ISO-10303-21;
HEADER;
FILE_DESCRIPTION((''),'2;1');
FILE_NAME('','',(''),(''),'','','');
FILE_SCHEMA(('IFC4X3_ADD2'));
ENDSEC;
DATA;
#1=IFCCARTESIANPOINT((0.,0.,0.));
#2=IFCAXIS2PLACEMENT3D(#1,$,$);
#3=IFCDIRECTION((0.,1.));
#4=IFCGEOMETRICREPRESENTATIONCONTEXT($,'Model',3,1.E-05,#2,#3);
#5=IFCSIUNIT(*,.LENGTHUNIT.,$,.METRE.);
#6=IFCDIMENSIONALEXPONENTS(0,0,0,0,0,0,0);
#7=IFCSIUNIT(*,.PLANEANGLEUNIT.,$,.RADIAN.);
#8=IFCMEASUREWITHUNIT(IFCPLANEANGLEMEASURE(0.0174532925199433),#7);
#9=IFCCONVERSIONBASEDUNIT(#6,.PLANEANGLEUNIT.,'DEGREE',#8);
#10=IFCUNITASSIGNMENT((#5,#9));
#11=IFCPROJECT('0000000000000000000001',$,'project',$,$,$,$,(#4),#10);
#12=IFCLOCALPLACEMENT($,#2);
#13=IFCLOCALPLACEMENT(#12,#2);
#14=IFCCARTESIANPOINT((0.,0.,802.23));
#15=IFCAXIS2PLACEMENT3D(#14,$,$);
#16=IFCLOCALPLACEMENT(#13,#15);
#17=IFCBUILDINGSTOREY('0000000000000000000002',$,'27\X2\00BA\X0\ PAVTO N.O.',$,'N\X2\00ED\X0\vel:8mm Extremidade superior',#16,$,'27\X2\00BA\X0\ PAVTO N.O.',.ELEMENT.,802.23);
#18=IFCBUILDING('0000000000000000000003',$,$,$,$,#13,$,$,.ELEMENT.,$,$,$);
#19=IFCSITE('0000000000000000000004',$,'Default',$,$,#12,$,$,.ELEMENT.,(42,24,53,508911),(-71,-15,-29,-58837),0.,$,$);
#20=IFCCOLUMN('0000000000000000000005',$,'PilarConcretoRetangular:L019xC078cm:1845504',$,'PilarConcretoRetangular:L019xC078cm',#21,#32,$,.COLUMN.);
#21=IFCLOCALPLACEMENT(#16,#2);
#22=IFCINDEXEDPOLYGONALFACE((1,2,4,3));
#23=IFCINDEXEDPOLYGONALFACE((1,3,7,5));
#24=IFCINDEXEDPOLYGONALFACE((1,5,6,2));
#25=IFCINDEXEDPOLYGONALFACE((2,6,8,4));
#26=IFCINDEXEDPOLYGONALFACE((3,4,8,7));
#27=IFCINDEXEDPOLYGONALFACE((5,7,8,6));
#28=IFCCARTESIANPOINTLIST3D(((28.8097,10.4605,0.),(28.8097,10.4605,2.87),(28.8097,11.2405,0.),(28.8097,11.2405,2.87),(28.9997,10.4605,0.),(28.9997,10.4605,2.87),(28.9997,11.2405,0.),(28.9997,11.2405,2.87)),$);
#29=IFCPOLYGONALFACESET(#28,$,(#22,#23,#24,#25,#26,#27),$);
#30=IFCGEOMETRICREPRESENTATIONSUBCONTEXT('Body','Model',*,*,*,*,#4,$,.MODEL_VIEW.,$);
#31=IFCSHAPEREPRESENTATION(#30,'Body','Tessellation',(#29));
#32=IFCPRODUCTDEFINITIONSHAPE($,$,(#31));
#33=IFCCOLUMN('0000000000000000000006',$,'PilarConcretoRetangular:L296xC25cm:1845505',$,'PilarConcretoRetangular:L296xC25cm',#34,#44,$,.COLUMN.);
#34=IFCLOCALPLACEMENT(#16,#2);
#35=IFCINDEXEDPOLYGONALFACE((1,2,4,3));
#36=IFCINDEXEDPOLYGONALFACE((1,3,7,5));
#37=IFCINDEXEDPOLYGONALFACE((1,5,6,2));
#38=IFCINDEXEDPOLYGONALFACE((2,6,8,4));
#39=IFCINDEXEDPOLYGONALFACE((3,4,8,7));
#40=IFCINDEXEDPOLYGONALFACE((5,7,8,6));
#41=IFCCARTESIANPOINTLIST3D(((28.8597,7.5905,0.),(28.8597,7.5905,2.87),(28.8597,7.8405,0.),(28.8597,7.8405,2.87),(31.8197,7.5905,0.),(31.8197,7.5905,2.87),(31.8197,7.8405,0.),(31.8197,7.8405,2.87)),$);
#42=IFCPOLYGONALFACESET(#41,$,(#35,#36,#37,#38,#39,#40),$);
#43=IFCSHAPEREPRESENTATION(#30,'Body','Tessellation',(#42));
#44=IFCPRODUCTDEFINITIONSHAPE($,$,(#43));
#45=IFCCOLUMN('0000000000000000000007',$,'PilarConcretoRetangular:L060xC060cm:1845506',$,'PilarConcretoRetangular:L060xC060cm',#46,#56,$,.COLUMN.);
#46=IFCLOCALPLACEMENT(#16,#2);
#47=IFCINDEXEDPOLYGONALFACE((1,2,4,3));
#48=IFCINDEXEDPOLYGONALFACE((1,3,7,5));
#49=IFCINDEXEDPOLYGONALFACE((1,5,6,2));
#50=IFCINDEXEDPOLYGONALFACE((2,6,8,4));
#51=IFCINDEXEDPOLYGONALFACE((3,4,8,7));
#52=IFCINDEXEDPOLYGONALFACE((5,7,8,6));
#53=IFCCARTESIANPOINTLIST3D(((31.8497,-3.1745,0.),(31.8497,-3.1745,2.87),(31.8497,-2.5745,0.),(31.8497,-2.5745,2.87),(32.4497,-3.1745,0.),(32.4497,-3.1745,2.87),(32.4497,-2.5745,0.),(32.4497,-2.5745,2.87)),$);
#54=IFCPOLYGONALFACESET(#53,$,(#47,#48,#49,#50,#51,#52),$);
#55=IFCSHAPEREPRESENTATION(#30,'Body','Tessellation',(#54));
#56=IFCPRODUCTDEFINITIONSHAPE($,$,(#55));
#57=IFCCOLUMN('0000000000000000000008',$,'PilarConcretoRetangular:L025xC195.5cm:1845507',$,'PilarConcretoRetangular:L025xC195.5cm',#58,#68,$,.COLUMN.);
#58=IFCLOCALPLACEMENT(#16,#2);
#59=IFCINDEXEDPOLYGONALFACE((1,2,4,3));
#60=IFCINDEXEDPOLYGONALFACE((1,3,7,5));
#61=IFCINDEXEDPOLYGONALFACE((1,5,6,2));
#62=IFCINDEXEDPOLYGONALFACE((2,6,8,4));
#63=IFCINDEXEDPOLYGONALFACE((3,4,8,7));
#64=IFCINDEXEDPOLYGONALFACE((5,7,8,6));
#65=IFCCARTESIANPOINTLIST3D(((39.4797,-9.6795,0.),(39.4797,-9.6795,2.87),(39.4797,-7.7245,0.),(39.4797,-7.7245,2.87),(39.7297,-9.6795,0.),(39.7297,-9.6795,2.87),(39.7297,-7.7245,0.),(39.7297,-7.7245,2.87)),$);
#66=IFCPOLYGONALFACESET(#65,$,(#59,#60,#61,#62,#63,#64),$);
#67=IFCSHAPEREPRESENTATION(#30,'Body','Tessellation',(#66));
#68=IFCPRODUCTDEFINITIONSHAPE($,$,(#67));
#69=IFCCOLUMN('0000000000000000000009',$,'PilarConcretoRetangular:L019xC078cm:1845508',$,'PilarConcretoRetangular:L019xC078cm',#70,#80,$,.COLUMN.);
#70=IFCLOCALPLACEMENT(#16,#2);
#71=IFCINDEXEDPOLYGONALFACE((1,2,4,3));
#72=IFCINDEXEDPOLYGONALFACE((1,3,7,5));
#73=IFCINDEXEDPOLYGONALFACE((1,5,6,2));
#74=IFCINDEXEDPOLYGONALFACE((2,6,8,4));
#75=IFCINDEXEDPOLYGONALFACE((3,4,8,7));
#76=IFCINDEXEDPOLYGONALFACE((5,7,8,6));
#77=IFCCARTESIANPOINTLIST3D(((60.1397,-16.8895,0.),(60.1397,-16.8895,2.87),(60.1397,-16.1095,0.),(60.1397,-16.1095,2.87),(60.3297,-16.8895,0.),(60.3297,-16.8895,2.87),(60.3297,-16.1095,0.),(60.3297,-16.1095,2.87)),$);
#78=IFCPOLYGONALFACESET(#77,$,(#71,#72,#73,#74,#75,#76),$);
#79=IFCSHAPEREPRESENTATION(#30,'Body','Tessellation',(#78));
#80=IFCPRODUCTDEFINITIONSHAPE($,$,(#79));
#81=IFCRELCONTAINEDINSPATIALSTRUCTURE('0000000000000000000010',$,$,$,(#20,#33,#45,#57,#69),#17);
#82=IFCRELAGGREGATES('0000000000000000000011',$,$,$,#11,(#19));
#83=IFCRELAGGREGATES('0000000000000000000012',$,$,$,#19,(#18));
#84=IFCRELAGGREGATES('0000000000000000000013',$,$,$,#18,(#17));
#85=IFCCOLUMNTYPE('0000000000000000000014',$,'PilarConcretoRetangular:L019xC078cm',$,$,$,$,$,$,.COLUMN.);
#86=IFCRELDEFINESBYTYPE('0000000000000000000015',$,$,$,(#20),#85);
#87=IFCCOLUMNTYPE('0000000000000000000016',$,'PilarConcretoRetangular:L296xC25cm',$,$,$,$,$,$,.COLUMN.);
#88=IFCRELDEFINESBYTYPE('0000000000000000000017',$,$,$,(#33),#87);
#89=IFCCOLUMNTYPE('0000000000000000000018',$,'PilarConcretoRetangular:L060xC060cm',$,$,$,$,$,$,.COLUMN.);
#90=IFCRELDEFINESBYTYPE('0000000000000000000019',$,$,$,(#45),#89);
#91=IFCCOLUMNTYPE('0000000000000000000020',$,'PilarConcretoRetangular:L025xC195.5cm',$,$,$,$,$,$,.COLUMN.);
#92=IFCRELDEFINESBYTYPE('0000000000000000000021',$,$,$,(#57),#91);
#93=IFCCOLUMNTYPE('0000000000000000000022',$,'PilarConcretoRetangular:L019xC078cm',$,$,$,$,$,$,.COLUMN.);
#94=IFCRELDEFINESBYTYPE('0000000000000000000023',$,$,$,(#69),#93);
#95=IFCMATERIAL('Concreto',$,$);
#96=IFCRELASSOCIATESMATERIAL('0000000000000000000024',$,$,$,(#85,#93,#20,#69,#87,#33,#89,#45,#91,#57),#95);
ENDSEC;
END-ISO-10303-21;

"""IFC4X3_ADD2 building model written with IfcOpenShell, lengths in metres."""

from ifc_helpers import new_model, entity, si_unit, converted_unit, direction, frame, frame_2d, origin, origin_2d_with_axis, place, context, subcontext, project, spatial, rectangle, extrude, source, transform, mapped, material, material_profile, profile_set, profile_usage, type_object, type_shapes, element, save


model = new_model("IFC4X3_ADD2")

# Units and contexts
model_context = context("Model", 3, precision=1e-05, world=origin(), true_north=direction((0.0, 1.0)))
body_context = subcontext(model_context, "Body", "Model", "MODEL_VIEW")
ifc_project = project(units=[si_unit("LENGTHUNIT", "METRE"), converted_unit("PLANEANGLEUNIT", "DEGREE", entity("IfcPlaneAngleMeasure", 0.0174532925199433), si_unit("PLANEANGLEUNIT", "RADIAN"), dimensions=[0, 0, 0, 0, 0, 0, 0])], contexts=[model_context])

# Site, building, storey
site_placement = place(None, origin())
site = spatial("IfcSite", under=ifc_project, at=site_placement, Name="Default", CompositionType="ELEMENT", RefLatitude=(42, 24, 53, 508911), RefLongitude=(-71, -15, -29, -58837), RefElevation=0.0)
building_placement = place(site_placement, origin())
building = spatial("IfcBuilding", under=site, at=building_placement, CompositionType="ELEMENT")
storey_placement = place(building_placement, frame((0.0, 0.0, 802.23)))
storey = spatial("IfcBuildingStorey", under=building, at=storey_placement, Name="27º PAVTO N.O.", ObjectType="Nível:8mm Extremidade superior", LongName="27º PAVTO N.O.", CompositionType="ELEMENT", Elevation=802.23)

# Columns
ifc_material = material(Name="Concreto")
ifc_material_profile_1 = material_profile(ifc_material, rectangle(XDim=0.6, YDim=0.6, at=origin_2d_with_axis()), Name="L060xC060cm")
ifc_profile_set_1 = profile_set([ifc_material_profile_1], Name="L060xC060cm")
ifc_profile_usage_1 = profile_usage(ifc_profile_set_1)
ifc_material_profile_2 = material_profile(ifc_material, rectangle(XDim=0.25, YDim=1.955, at=frame_2d((0.0, 0.0), x_axis=(1.0, 0.0))), Name="L025xC195.5cm")
ifc_profile_set_2 = profile_set([ifc_material_profile_2], Name="L025xC195.5cm")
ifc_profile_usage_2 = profile_usage(ifc_profile_set_2)
ifc_material_profile_3 = material_profile(ifc_material, rectangle(XDim=0.19, YDim=0.78, at=frame_2d((0.0, 0.0), x_axis=(1.0, 0.0))), Name="L019xC078cm")
ifc_profile_set_3 = profile_set([ifc_material_profile_3], Name="L019xC078cm")
ifc_profile_usage_3 = profile_usage(ifc_profile_set_3)
column_type_1 = type_object("IfcColumnType", Name="PilarConcretoRetangular:L019xC078cm", PredefinedType="COLUMN", material=ifc_profile_set_3)
shared_shape_1 = source(origin(), body_context, "Body", "SweptSolid", [
    extrude(rectangle(XDim=0.19, YDim=0.78, at=frame_2d((0.0, 0.0), x_axis=(1.0, 0.0))), frame((28.9047, 10.8505, 802.23), z_axis=(0.0, 0.0, 1.0), x_axis=(-1.0, 0.0, 0.0)), (0.0, 0.0, 1.0), 2.87),
])
type_shapes(column_type_1, [shared_shape_1])
column_1_placement = place(storey_placement, frame((0.0, 0.0, -802.23)))
element("IfcColumn", 1, at=column_1_placement, inside=storey, type_object=column_type_1, material=ifc_profile_usage_3, Name="PilarConcretoRetangular:L019xC078cm:1845504", ObjectType="PilarConcretoRetangular:L019xC078cm", PredefinedType="COLUMN", context=body_context, shape_type="MappedRepresentation", body=[
    mapped(shared_shape_1, transform((0.0, 0.0, 0.0), scale=1.0)),
])
ifc_material_profile_4 = material_profile(ifc_material, rectangle(XDim=2.96, YDim=0.25, at=frame_2d((0.0, 0.0), x_axis=(1.0, 0.0))), Name="L296xC25cm")
ifc_profile_set_4 = profile_set([ifc_material_profile_4], Name="L296xC25cm")
ifc_profile_usage_4 = profile_usage(ifc_profile_set_4)
column_type_2 = type_object("IfcColumnType", Name="PilarConcretoRetangular:L296xC25cm", PredefinedType="COLUMN", material=ifc_profile_set_4)
shared_shape_2 = source(origin(), body_context, "Body", "SweptSolid", [
    extrude(rectangle(XDim=2.96, YDim=0.25, at=frame_2d((0.0, 0.0), x_axis=(1.0, 0.0))), frame((30.3397, 7.7155, 802.23), z_axis=(0.0, 0.0, 1.0), x_axis=(-1.0, 0.0, 0.0)), (0.0, 0.0, 1.0), 2.87),
])
type_shapes(column_type_2, [shared_shape_2])
column_2_placement = place(storey_placement, frame((0.0, 0.0, -802.23)))
element("IfcColumn", 2, at=column_2_placement, inside=storey, type_object=column_type_2, material=ifc_profile_usage_4, Name="PilarConcretoRetangular:L296xC25cm:1845505", ObjectType="PilarConcretoRetangular:L296xC25cm", PredefinedType="COLUMN", context=body_context, shape_type="MappedRepresentation", body=[
    mapped(shared_shape_2, transform((0.0, 0.0, 0.0), scale=1.0)),
])
column_type_3 = type_object("IfcColumnType", Name="PilarConcretoRetangular:L060xC060cm", PredefinedType="COLUMN", material=ifc_profile_set_1)
shared_shape_3 = source(origin(), body_context, "Body", "SweptSolid", [
    extrude(rectangle(XDim=0.6, YDim=0.6, at=frame_2d((0.0, 0.0), x_axis=(1.0, 0.0))), frame((32.1497, -2.8745, 802.23), z_axis=(0.0, 0.0, 1.0), x_axis=(-1.0, 0.0, 0.0)), (0.0, 0.0, 1.0), 2.87),
])
type_shapes(column_type_3, [shared_shape_3])
column_3_placement = place(storey_placement, frame((0.0, 0.0, -802.23)))
element("IfcColumn", 3, at=column_3_placement, inside=storey, type_object=column_type_3, material=ifc_profile_usage_1, Name="PilarConcretoRetangular:L060xC060cm:1845506", ObjectType="PilarConcretoRetangular:L060xC060cm", PredefinedType="COLUMN", context=body_context, shape_type="MappedRepresentation", body=[
    mapped(shared_shape_3, transform((0.0, 0.0, 0.0), scale=1.0)),
])
column_type_4 = type_object("IfcColumnType", Name="PilarConcretoRetangular:L025xC195.5cm", PredefinedType="COLUMN", material=ifc_profile_set_2)
shared_shape_4 = source(origin(), body_context, "Body", "SweptSolid", [
    extrude(rectangle(XDim=0.25, YDim=1.955, at=frame_2d((0.0, 0.0), x_axis=(1.0, 0.0))), frame((39.6047, -8.702, 802.23), z_axis=(0.0, 0.0, 1.0), x_axis=(-1.0, 0.0, 0.0)), (0.0, 0.0, 1.0), 2.87),
])
type_shapes(column_type_4, [shared_shape_4])
column_4_placement = place(storey_placement, frame((0.0, 0.0, -802.23)))
element("IfcColumn", 4, at=column_4_placement, inside=storey, type_object=column_type_4, material=ifc_profile_usage_2, Name="PilarConcretoRetangular:L025xC195.5cm:1845507", ObjectType="PilarConcretoRetangular:L025xC195.5cm", PredefinedType="COLUMN", context=body_context, shape_type="MappedRepresentation", body=[
    mapped(shared_shape_4, transform((0.0, 0.0, 0.0), scale=1.0)),
])
column_type_5 = type_object("IfcColumnType", Name="PilarConcretoRetangular:L019xC078cm", PredefinedType="COLUMN", material=ifc_profile_set_3)
shared_shape_5 = source(origin(), body_context, "Body", "SweptSolid", [
    extrude(rectangle(XDim=0.19, YDim=0.78, at=frame_2d((0.0, 0.0), x_axis=(1.0, 0.0))), frame((60.2347, -16.4995, 802.23), z_axis=(0.0, 0.0, 1.0), x_axis=(-1.0, 0.0, 0.0)), (0.0, 0.0, 1.0), 2.87),
])
type_shapes(column_type_5, [shared_shape_5])
column_5_placement = place(storey_placement, frame((0.0, 0.0, -802.23)))
element("IfcColumn", 5, at=column_5_placement, inside=storey, type_object=column_type_5, material=ifc_profile_usage_3, Name="PilarConcretoRetangular:L019xC078cm:1845508", ObjectType="PilarConcretoRetangular:L019xC078cm", PredefinedType="COLUMN", context=body_context, shape_type="MappedRepresentation", body=[
    mapped(shared_shape_5, transform((0.0, 0.0, 0.0), scale=1.0)),
])

save(model, "model.ifc")
